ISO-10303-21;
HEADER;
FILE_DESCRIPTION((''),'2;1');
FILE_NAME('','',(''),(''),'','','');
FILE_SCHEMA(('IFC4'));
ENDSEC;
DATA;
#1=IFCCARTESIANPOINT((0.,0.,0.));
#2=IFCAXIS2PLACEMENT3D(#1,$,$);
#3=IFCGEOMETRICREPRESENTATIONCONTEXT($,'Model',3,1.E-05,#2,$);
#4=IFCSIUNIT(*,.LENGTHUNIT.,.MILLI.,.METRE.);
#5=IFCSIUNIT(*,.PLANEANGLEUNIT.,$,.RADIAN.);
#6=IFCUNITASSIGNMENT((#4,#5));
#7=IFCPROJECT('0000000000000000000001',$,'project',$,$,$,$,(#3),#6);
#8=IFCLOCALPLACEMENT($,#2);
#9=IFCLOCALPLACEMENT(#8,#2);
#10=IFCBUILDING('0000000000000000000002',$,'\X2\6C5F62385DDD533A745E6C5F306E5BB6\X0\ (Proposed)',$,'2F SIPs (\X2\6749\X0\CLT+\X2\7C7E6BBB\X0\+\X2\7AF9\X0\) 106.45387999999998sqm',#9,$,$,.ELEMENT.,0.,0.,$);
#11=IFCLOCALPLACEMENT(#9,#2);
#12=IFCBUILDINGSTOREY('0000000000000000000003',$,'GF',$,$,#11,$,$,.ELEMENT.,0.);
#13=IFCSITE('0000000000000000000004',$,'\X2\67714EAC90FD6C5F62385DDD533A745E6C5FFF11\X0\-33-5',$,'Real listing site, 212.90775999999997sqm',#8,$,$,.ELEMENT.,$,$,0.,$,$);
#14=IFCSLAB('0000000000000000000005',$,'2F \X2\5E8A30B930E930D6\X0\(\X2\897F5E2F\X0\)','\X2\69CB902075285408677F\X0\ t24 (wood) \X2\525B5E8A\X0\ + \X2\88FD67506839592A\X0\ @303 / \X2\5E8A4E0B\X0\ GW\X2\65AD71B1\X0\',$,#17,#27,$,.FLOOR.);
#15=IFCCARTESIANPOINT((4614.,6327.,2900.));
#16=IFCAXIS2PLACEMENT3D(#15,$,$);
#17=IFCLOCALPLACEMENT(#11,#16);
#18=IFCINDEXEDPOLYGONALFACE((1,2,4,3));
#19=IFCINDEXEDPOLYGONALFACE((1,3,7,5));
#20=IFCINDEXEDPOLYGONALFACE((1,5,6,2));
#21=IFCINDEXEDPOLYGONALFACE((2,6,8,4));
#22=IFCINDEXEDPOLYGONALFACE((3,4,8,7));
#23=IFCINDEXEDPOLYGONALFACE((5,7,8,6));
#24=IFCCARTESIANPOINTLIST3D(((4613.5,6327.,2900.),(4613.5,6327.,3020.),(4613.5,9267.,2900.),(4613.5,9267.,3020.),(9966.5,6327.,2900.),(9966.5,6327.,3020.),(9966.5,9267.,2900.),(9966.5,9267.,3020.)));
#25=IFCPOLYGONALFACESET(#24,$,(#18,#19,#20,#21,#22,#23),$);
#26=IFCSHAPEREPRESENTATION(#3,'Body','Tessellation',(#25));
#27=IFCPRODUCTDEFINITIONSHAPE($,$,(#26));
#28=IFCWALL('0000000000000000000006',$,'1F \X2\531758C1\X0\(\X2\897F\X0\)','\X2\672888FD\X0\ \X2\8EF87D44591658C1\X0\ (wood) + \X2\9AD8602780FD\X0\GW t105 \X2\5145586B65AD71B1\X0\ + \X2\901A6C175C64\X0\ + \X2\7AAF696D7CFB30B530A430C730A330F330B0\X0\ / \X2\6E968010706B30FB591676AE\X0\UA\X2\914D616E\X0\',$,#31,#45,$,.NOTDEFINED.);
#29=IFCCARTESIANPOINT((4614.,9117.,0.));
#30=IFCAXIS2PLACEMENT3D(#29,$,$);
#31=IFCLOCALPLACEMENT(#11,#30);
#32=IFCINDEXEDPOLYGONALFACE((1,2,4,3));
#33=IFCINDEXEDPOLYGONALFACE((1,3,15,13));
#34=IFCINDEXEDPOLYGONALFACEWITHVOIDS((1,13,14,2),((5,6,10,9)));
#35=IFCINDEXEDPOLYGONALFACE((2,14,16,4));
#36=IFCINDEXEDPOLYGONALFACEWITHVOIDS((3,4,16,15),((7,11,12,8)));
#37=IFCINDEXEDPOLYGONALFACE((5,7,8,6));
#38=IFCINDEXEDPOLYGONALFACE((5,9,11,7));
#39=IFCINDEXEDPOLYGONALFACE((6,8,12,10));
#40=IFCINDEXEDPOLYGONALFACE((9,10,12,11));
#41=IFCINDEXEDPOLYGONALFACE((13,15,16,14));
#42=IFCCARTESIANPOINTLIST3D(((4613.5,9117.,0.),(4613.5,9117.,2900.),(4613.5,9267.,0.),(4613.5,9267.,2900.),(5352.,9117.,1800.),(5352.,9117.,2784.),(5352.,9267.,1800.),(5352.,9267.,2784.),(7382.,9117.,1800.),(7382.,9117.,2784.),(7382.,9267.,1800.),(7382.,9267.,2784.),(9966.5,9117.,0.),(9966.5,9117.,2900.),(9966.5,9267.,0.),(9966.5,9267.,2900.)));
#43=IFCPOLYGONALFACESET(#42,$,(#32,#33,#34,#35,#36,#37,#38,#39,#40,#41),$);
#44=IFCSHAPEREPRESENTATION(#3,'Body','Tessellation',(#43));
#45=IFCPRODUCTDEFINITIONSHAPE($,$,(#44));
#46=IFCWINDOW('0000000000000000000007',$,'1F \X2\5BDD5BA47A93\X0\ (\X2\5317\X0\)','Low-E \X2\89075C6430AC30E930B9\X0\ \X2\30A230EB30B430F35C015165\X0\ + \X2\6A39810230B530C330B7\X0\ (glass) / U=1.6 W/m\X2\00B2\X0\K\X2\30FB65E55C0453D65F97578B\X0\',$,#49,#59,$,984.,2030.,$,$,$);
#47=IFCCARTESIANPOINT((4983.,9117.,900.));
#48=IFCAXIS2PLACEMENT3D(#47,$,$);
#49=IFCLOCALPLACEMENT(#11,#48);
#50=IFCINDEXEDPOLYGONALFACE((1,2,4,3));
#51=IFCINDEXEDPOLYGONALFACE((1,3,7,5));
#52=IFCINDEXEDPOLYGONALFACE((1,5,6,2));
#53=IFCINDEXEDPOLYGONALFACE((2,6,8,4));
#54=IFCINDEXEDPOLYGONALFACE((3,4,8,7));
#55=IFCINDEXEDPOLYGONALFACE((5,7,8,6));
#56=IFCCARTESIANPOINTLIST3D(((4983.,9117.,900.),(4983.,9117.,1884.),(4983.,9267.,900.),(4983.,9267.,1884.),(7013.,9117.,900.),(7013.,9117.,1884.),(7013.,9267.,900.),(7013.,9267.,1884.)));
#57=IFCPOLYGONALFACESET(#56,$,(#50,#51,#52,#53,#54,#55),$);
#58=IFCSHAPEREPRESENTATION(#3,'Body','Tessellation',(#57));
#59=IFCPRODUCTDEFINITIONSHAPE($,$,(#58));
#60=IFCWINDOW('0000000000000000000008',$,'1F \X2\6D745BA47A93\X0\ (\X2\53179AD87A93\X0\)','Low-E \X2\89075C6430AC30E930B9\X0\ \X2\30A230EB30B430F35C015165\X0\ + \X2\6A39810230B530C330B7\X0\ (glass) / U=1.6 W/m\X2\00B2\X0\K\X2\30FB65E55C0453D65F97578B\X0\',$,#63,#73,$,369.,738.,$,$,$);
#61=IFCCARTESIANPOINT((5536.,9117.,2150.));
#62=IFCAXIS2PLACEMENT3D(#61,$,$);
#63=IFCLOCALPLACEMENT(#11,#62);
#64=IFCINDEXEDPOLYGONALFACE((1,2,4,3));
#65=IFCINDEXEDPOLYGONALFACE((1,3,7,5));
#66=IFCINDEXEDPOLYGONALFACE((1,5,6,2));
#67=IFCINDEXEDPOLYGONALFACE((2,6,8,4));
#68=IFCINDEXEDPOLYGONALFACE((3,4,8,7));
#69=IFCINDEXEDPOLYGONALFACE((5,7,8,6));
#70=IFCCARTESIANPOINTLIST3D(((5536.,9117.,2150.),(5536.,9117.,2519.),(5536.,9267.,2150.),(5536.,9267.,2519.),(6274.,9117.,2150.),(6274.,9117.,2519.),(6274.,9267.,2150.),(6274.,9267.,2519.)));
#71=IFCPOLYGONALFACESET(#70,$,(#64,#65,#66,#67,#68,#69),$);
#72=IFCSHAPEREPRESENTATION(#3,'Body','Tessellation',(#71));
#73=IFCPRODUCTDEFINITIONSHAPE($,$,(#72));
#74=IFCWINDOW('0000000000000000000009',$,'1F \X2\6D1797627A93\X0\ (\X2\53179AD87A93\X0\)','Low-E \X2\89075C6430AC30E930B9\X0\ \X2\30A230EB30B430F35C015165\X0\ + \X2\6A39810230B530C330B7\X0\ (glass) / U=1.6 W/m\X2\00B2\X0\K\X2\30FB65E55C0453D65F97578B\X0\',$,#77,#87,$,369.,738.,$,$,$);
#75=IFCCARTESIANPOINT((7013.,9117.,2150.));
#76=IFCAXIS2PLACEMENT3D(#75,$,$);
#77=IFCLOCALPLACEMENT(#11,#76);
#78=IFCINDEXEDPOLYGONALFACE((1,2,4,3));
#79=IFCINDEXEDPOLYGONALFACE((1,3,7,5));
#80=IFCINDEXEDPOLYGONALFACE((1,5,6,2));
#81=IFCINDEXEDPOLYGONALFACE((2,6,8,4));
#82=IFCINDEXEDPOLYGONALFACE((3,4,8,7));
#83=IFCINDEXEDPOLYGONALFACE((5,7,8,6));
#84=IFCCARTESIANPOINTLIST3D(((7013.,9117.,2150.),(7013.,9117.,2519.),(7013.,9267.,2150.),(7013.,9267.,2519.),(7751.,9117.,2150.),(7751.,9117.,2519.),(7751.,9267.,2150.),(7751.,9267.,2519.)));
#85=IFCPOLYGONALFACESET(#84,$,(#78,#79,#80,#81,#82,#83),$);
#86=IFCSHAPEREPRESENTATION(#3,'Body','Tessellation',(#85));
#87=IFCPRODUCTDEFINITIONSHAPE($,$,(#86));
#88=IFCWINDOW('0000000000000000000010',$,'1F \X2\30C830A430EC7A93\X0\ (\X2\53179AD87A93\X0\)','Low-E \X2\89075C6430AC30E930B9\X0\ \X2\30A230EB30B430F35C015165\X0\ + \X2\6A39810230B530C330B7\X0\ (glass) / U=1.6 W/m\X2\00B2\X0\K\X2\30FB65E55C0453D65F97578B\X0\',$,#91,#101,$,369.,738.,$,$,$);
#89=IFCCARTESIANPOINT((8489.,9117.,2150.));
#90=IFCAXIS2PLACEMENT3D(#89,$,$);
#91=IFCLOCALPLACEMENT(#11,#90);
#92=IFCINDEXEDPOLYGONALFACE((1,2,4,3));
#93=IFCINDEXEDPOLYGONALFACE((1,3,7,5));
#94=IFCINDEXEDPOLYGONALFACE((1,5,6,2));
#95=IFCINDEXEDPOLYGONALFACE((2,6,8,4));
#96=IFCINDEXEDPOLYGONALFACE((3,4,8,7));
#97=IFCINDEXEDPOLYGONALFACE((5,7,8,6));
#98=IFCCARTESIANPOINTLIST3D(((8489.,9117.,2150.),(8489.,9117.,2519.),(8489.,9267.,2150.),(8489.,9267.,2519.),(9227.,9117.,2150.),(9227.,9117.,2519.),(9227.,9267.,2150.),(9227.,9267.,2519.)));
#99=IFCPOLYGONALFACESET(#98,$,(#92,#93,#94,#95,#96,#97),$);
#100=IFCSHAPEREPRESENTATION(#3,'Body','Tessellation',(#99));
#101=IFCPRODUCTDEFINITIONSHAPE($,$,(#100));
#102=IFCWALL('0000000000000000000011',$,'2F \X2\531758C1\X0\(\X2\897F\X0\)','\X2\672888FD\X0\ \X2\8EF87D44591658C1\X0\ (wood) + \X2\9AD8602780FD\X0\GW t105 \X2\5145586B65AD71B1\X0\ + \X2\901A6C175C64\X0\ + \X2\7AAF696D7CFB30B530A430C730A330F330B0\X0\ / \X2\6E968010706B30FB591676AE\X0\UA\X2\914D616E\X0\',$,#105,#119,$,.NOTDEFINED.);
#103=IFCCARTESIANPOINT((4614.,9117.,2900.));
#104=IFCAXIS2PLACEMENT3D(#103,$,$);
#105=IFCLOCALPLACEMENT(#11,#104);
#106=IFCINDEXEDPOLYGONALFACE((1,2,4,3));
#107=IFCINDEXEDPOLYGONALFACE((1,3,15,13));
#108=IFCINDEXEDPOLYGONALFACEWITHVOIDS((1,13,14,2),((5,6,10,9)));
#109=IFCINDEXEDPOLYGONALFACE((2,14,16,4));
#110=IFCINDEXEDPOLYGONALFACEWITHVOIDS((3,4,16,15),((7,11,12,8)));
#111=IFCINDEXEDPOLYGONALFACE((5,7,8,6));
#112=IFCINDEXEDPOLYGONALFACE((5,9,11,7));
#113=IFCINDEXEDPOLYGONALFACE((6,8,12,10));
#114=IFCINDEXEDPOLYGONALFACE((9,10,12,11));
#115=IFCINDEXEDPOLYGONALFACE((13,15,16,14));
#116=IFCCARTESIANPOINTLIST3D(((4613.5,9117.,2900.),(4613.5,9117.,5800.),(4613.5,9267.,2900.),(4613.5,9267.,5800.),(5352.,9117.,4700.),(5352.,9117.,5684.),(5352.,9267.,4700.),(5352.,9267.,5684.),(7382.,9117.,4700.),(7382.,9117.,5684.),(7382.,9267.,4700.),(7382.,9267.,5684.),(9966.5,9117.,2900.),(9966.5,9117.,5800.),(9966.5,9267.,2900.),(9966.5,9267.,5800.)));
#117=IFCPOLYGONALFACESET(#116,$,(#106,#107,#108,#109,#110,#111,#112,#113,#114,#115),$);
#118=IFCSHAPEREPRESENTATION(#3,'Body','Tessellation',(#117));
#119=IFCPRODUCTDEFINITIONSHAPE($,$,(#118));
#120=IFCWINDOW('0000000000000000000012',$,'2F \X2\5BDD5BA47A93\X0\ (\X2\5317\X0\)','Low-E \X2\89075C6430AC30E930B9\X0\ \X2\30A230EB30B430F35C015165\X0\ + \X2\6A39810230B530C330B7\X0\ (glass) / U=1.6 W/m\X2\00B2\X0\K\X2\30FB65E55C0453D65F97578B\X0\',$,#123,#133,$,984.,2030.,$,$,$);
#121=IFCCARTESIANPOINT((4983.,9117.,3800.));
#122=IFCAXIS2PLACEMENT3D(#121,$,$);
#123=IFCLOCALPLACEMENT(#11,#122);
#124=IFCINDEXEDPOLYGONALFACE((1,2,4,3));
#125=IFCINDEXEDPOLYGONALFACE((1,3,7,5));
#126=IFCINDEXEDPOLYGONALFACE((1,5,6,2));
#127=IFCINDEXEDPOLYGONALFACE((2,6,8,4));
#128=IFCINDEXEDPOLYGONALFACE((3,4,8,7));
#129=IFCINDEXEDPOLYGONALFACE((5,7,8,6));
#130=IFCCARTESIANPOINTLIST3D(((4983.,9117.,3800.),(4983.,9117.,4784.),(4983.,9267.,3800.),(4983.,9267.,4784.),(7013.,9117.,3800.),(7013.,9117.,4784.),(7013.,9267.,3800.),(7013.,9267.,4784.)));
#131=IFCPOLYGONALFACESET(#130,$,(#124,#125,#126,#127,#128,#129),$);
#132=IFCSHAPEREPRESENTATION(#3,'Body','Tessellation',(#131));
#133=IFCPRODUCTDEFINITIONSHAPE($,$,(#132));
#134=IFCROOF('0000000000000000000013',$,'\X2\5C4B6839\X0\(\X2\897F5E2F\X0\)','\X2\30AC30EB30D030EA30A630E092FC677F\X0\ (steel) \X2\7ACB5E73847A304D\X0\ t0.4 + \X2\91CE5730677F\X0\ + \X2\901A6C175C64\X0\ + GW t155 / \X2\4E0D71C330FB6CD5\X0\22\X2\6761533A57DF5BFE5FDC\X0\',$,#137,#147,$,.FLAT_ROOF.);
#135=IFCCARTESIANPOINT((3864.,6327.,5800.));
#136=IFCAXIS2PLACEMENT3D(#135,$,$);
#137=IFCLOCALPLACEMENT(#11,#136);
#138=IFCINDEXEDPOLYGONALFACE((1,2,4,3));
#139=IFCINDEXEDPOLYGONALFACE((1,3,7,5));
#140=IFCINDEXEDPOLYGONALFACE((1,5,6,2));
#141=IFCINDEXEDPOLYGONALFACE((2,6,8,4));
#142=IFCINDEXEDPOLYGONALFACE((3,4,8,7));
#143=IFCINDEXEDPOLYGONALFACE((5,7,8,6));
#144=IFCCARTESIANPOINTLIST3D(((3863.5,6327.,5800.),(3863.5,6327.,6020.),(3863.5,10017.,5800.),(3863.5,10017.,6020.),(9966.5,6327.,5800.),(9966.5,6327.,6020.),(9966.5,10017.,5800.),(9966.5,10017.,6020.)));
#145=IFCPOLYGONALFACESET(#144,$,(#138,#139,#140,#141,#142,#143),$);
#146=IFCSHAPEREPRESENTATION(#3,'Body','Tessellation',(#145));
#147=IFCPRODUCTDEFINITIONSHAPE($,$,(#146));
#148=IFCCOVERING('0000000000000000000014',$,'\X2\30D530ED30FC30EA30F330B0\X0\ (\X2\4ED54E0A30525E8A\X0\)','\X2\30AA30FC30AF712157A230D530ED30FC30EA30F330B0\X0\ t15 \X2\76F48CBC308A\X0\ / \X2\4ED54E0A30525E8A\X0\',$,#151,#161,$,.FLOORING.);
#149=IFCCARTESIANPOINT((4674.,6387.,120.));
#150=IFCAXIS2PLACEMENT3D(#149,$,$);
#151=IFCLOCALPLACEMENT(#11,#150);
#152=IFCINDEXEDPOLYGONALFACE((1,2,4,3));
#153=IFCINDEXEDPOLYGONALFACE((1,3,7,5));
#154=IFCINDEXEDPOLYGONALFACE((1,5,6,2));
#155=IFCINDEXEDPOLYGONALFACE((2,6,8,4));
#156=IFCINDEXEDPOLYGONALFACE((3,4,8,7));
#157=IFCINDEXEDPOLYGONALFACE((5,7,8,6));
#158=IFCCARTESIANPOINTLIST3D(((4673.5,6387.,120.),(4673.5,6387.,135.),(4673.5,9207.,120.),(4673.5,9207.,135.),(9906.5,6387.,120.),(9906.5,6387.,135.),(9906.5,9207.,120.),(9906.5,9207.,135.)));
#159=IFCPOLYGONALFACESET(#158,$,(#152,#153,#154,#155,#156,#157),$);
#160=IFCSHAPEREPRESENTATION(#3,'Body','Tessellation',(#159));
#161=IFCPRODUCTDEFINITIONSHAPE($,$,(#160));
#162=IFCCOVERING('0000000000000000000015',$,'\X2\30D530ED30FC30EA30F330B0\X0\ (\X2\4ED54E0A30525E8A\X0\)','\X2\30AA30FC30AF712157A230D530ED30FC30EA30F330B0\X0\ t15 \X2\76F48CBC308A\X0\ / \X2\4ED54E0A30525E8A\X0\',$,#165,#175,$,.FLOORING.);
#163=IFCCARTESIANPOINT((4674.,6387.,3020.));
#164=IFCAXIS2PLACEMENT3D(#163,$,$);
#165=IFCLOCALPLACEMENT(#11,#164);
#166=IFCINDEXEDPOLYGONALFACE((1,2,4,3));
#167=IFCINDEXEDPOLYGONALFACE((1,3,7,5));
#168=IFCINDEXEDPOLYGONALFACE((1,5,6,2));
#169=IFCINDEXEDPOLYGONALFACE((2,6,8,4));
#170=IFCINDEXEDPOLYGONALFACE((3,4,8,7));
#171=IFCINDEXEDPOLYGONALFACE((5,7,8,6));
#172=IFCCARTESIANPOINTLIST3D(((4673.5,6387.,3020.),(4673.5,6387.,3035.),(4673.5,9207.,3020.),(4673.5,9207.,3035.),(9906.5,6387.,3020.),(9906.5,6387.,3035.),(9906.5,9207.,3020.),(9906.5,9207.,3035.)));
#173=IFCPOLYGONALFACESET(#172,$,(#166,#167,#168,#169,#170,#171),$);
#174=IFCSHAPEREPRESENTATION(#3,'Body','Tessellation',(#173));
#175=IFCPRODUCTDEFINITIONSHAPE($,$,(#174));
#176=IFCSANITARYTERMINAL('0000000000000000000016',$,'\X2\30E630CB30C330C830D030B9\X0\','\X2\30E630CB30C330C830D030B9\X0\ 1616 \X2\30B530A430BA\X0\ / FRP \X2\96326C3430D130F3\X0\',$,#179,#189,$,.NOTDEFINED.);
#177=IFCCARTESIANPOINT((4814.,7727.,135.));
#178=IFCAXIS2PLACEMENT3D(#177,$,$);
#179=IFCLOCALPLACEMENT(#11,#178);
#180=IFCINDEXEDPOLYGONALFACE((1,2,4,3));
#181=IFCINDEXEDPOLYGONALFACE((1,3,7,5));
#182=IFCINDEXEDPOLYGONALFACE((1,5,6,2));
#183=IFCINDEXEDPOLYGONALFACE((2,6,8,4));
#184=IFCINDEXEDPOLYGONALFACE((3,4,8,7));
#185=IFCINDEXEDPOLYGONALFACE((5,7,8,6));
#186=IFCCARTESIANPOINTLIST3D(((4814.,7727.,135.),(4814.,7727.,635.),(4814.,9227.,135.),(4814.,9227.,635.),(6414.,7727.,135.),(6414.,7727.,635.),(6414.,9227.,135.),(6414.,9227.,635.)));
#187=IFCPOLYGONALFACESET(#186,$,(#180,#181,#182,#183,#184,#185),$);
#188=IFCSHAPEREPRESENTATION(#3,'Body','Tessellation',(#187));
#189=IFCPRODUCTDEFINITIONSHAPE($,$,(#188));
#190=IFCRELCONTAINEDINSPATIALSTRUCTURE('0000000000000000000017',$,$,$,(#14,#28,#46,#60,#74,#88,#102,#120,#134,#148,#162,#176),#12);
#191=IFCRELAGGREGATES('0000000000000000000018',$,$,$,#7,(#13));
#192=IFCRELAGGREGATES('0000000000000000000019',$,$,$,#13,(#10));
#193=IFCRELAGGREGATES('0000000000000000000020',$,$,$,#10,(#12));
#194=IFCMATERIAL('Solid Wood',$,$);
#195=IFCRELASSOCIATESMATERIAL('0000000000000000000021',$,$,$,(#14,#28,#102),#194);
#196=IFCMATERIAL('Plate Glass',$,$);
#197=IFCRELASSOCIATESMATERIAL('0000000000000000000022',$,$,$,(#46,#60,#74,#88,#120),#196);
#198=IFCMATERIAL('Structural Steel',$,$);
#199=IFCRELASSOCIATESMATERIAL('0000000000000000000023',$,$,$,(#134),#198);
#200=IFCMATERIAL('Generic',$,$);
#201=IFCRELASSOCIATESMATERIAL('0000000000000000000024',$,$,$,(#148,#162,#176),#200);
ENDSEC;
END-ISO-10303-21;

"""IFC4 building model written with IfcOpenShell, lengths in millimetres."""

from ifc_helpers import new_model, si_unit, frame, frame_2d, origin, place, context, project, spatial, rectangle, extrude, material, element, fill, save


model = new_model("IFC4")

# Units and contexts
model_context = context("Model", 3, precision=1e-05, world=origin())
ifc_project = project(units=[si_unit("LENGTHUNIT", "METRE", prefix="MILLI"), si_unit("PLANEANGLEUNIT", "RADIAN")], contexts=[model_context])

# Site, building, storey
site_placement = place(None, origin())
site = spatial("IfcSite", under=ifc_project, at=site_placement, Name="東京都江戸川区瑞江１-33-5", ObjectType="Real listing site, 212.90775999999997sqm", CompositionType="ELEMENT", RefElevation=0.0)
building_placement = place(site_placement, origin())
building = spatial("IfcBuilding", under=site, at=building_placement, Name="江戸川区瑞江の家 (Proposed)", ObjectType="2F SIPs (杉CLT+籾殻+竹) 106.45387999999998sqm", CompositionType="ELEMENT", ElevationOfRefHeight=0.0, ElevationOfTerrain=0.0)
storey_placement = place(building_placement, origin())
storey = spatial("IfcBuildingStorey", under=building, at=storey_placement, Name="GF", CompositionType="ELEMENT", Elevation=0.0)

# Slab
ifc_material_1 = material(Name="Solid Wood")
slab_1_placement = place(storey_placement, frame((4614.0, 6327.0, 2900.0)))
element("IfcSlab", 1, at=slab_1_placement, inside=storey, material=ifc_material_1, Name="2F 床スラブ(西帯)", Description="構造用合板 t24 (wood) 剛床 + 製材根太 @303 / 床下 GW断熱", PredefinedType="FLOOR", context=model_context, shape_type="SweptSolid", body=[
    extrude(rectangle(XDim=5353.0, YDim=2940.0, at=frame_2d((2676.0, 1470.0))), frame((4614.0, 6327.0, 2900.0)), (0.0, 0.0, 1.0), 120.0),
])

# Wall, openings, windows
wall_1_placement = place(storey_placement, frame((4614.0, 9117.0, 0.0)))
wall_1 = element("IfcWall", 2, at=wall_1_placement, inside=storey, material=ifc_material_1, Name="1F 北壁(西)", Description="木製 軸組外壁 (wood) + 高性能GW t105 充填断熱 + 通気層 + 窯業系サイディング / 準耐火・外皮UA配慮", PredefinedType="NOTDEFINED", context=model_context, shape_type="SweptSolid", body=[
    extrude(rectangle(XDim=5353.0, YDim=150.0, at=frame_2d((2676.0, 75.0))), frame((4614.0, 9117.0, 0.0)), (0.0, 0.0, 1.0), 2900.0),
])
opening_1_placement = place(storey_placement, frame((4983.0, 9117.0, 900.0)))
opening_1 = element("IfcOpeningElement", 3, at=opening_1_placement, cuts=wall_1, PredefinedType="NOTDEFINED", context=model_context, shape_type="SweptSolid", body=[
    extrude(rectangle(XDim=2030.0, YDim=150.0, at=frame_2d((1015.0, 75.0))), frame((4983.0, 9117.0, 900.0)), (0.0, 0.0, 1.0), 984.0),
])
opening_2_placement = place(storey_placement, frame((5536.0, 9117.0, 2150.0)))
opening_2 = element("IfcOpeningElement", 4, at=opening_2_placement, cuts=wall_1, PredefinedType="NOTDEFINED", context=model_context, shape_type="SweptSolid", body=[
    extrude(rectangle(XDim=738.0, YDim=150.0, at=frame_2d((369.0, 75.0))), frame((5536.0, 9117.0, 2150.0)), (0.0, 0.0, 1.0), 369.0),
])
opening_3_placement = place(storey_placement, frame((7013.0, 9117.0, 2150.0)))
opening_3 = element("IfcOpeningElement", 5, at=opening_3_placement, cuts=wall_1, PredefinedType="NOTDEFINED", context=model_context, shape_type="SweptSolid", body=[
    extrude(rectangle(XDim=738.0, YDim=150.0, at=frame_2d((369.0, 75.0))), frame((7013.0, 9117.0, 2150.0)), (0.0, 0.0, 1.0), 369.0),
])
opening_4_placement = place(storey_placement, frame((8489.0, 9117.0, 2150.0)))
opening_4 = element("IfcOpeningElement", 6, at=opening_4_placement, cuts=wall_1, PredefinedType="NOTDEFINED", context=model_context, shape_type="SweptSolid", body=[
    extrude(rectangle(XDim=738.0, YDim=150.0, at=frame_2d((369.0, 75.0))), frame((8489.0, 9117.0, 2150.0)), (0.0, 0.0, 1.0), 369.0),
])
ifc_material_2 = material(Name="Plate Glass")
window_1_placement = place(storey_placement, frame((4983.0, 9117.0, 900.0)))
window_1 = element("IfcWindow", 7, at=window_1_placement, inside=storey, material=ifc_material_2, Name="1F 寝室窓 (北)", Description="Low-E 複層ガラス アルゴン封入 + 樹脂サッシ (glass) / U=1.6 W/m²K・日射取得型", OverallHeight=984.0, OverallWidth=2030.0, context=model_context, shape_type="SweptSolid", body=[
    extrude(rectangle(XDim=2030.0, YDim=150.0, at=frame_2d((1015.0, 75.0))), frame((4983.0, 9117.0, 900.0)), (0.0, 0.0, 1.0), 984.0),
])
fill(opening_1, window_1)
window_2_placement = place(storey_placement, frame((5536.0, 9117.0, 2150.0)))
window_2 = element("IfcWindow", 8, at=window_2_placement, inside=storey, material=ifc_material_2, Name="1F 浴室窓 (北高窓)", Description="Low-E 複層ガラス アルゴン封入 + 樹脂サッシ (glass) / U=1.6 W/m²K・日射取得型", OverallHeight=369.0, OverallWidth=738.0, context=model_context, shape_type="SweptSolid", body=[
    extrude(rectangle(XDim=738.0, YDim=150.0, at=frame_2d((369.0, 75.0))), frame((5536.0, 9117.0, 2150.0)), (0.0, 0.0, 1.0), 369.0),
])
fill(opening_2, window_2)
window_3_placement = place(storey_placement, frame((7013.0, 9117.0, 2150.0)))
window_3 = element("IfcWindow", 9, at=window_3_placement, inside=storey, material=ifc_material_2, Name="1F 洗面窓 (北高窓)", Description="Low-E 複層ガラス アルゴン封入 + 樹脂サッシ (glass) / U=1.6 W/m²K・日射取得型", OverallHeight=369.0, OverallWidth=738.0, context=model_context, shape_type="SweptSolid", body=[
    extrude(rectangle(XDim=738.0, YDim=150.0, at=frame_2d((369.0, 75.0))), frame((7013.0, 9117.0, 2150.0)), (0.0, 0.0, 1.0), 369.0),
])
fill(opening_3, window_3)
window_4_placement = place(storey_placement, frame((8489.0, 9117.0, 2150.0)))
window_4 = element("IfcWindow", 10, at=window_4_placement, inside=storey, material=ifc_material_2, Name="1F トイレ窓 (北高窓)", Description="Low-E 複層ガラス アルゴン封入 + 樹脂サッシ (glass) / U=1.6 W/m²K・日射取得型", OverallHeight=369.0, OverallWidth=738.0, context=model_context, shape_type="SweptSolid", body=[
    extrude(rectangle(XDim=738.0, YDim=150.0, at=frame_2d((369.0, 75.0))), frame((8489.0, 9117.0, 2150.0)), (0.0, 0.0, 1.0), 369.0),
])
fill(opening_4, window_4)

# Wall, opening, window
wall_2_placement = place(storey_placement, frame((4614.0, 9117.0, 2900.0)))
wall_2 = element("IfcWall", 11, at=wall_2_placement, inside=storey, material=ifc_material_1, Name="2F 北壁(西)", Description="木製 軸組外壁 (wood) + 高性能GW t105 充填断熱 + 通気層 + 窯業系サイディング / 準耐火・外皮UA配慮", PredefinedType="NOTDEFINED", context=model_context, shape_type="SweptSolid", body=[
    extrude(rectangle(XDim=5353.0, YDim=150.0, at=frame_2d((2676.0, 75.0))), frame((4614.0, 9117.0, 2900.0)), (0.0, 0.0, 1.0), 2900.0),
])
opening_5_placement = place(storey_placement, frame((4983.0, 9117.0, 3800.0)))
opening_5 = element("IfcOpeningElement", 12, at=opening_5_placement, cuts=wall_2, PredefinedType="NOTDEFINED", context=model_context, shape_type="SweptSolid", body=[
    extrude(rectangle(XDim=2030.0, YDim=150.0, at=frame_2d((1015.0, 75.0))), frame((4983.0, 9117.0, 3800.0)), (0.0, 0.0, 1.0), 984.0),
])
window_5_placement = place(storey_placement, frame((4983.0, 9117.0, 3800.0)))
window_5 = element("IfcWindow", 13, at=window_5_placement, inside=storey, material=ifc_material_2, Name="2F 寝室窓 (北)", Description="Low-E 複層ガラス アルゴン封入 + 樹脂サッシ (glass) / U=1.6 W/m²K・日射取得型", OverallHeight=984.0, OverallWidth=2030.0, context=model_context, shape_type="SweptSolid", body=[
    extrude(rectangle(XDim=2030.0, YDim=150.0, at=frame_2d((1015.0, 75.0))), frame((4983.0, 9117.0, 3800.0)), (0.0, 0.0, 1.0), 984.0),
])
fill(opening_5, window_5)

# Roof
ifc_material_3 = material(Name="Structural Steel")
for number, where, name in (
    (14, (3864.0, 6327.0, 5800.0), "屋根(西帯)"),
):
    element("IfcRoof", number, at=place(storey_placement, frame(where)), inside=storey, material=ifc_material_3, Name=name, Description="ガルバリウム鋼板 (steel) 立平葺き t0.4 + 野地板 + 通気層 + GW t155 / 不燃・法22条区域対応", PredefinedType="FLAT_ROOF", context=model_context, shape_type="SweptSolid", body=[
        extrude(rectangle(XDim=6103.0, YDim=3690.0, at=frame_2d((3051.0, 1845.0))), frame((3864.0, 6327.0, 5800.0)), (0.0, 0.0, 1.0), 220.0),
    ])

# Coverings
ifc_material_4 = material(Name="Generic")
covering_1_placement = place(storey_placement, frame((4674.0, 6387.0, 120.0)))
element("IfcCovering", 15, at=covering_1_placement, inside=storey, material=ifc_material_4, Name="フローリング (仕上げ床)", Description="オーク無垢フローリング t15 直貼り / 仕上げ床", PredefinedType="FLOORING", context=model_context, shape_type="SweptSolid", body=[
    extrude(rectangle(XDim=5233.0, YDim=2820.0, at=frame_2d((2616.0, 1410.0))), frame((4674.0, 6387.0, 120.0)), (0.0, 0.0, 1.0), 15.0),
])
covering_2_placement = place(storey_placement, frame((4674.0, 6387.0, 3020.0)))
element("IfcCovering", 16, at=covering_2_placement, inside=storey, material=ifc_material_4, Name="フローリング (仕上げ床)", Description="オーク無垢フローリング t15 直貼り / 仕上げ床", PredefinedType="FLOORING", context=model_context, shape_type="SweptSolid", body=[
    extrude(rectangle(XDim=5233.0, YDim=2820.0, at=frame_2d((2616.0, 1410.0))), frame((4674.0, 6387.0, 3020.0)), (0.0, 0.0, 1.0), 15.0),
])

# Sanitary terminal
sanitary_terminal_placement = place(storey_placement, frame((4814.0, 7727.0, 135.0)))
element("IfcSanitaryTerminal", 17, at=sanitary_terminal_placement, inside=storey, material=ifc_material_4, Name="ユニットバス", Description="ユニットバス 1616 サイズ / FRP 防水パン", PredefinedType="NOTDEFINED", context=model_context, shape_type="SweptSolid", body=[
    extrude(rectangle(XDim=1600.0, YDim=1500.0, at=frame_2d((800.0, 750.0))), frame((4814.0, 7727.0, 135.0)), (0.0, 0.0, 1.0), 500.0),
])

save(model, "model.ifc")
